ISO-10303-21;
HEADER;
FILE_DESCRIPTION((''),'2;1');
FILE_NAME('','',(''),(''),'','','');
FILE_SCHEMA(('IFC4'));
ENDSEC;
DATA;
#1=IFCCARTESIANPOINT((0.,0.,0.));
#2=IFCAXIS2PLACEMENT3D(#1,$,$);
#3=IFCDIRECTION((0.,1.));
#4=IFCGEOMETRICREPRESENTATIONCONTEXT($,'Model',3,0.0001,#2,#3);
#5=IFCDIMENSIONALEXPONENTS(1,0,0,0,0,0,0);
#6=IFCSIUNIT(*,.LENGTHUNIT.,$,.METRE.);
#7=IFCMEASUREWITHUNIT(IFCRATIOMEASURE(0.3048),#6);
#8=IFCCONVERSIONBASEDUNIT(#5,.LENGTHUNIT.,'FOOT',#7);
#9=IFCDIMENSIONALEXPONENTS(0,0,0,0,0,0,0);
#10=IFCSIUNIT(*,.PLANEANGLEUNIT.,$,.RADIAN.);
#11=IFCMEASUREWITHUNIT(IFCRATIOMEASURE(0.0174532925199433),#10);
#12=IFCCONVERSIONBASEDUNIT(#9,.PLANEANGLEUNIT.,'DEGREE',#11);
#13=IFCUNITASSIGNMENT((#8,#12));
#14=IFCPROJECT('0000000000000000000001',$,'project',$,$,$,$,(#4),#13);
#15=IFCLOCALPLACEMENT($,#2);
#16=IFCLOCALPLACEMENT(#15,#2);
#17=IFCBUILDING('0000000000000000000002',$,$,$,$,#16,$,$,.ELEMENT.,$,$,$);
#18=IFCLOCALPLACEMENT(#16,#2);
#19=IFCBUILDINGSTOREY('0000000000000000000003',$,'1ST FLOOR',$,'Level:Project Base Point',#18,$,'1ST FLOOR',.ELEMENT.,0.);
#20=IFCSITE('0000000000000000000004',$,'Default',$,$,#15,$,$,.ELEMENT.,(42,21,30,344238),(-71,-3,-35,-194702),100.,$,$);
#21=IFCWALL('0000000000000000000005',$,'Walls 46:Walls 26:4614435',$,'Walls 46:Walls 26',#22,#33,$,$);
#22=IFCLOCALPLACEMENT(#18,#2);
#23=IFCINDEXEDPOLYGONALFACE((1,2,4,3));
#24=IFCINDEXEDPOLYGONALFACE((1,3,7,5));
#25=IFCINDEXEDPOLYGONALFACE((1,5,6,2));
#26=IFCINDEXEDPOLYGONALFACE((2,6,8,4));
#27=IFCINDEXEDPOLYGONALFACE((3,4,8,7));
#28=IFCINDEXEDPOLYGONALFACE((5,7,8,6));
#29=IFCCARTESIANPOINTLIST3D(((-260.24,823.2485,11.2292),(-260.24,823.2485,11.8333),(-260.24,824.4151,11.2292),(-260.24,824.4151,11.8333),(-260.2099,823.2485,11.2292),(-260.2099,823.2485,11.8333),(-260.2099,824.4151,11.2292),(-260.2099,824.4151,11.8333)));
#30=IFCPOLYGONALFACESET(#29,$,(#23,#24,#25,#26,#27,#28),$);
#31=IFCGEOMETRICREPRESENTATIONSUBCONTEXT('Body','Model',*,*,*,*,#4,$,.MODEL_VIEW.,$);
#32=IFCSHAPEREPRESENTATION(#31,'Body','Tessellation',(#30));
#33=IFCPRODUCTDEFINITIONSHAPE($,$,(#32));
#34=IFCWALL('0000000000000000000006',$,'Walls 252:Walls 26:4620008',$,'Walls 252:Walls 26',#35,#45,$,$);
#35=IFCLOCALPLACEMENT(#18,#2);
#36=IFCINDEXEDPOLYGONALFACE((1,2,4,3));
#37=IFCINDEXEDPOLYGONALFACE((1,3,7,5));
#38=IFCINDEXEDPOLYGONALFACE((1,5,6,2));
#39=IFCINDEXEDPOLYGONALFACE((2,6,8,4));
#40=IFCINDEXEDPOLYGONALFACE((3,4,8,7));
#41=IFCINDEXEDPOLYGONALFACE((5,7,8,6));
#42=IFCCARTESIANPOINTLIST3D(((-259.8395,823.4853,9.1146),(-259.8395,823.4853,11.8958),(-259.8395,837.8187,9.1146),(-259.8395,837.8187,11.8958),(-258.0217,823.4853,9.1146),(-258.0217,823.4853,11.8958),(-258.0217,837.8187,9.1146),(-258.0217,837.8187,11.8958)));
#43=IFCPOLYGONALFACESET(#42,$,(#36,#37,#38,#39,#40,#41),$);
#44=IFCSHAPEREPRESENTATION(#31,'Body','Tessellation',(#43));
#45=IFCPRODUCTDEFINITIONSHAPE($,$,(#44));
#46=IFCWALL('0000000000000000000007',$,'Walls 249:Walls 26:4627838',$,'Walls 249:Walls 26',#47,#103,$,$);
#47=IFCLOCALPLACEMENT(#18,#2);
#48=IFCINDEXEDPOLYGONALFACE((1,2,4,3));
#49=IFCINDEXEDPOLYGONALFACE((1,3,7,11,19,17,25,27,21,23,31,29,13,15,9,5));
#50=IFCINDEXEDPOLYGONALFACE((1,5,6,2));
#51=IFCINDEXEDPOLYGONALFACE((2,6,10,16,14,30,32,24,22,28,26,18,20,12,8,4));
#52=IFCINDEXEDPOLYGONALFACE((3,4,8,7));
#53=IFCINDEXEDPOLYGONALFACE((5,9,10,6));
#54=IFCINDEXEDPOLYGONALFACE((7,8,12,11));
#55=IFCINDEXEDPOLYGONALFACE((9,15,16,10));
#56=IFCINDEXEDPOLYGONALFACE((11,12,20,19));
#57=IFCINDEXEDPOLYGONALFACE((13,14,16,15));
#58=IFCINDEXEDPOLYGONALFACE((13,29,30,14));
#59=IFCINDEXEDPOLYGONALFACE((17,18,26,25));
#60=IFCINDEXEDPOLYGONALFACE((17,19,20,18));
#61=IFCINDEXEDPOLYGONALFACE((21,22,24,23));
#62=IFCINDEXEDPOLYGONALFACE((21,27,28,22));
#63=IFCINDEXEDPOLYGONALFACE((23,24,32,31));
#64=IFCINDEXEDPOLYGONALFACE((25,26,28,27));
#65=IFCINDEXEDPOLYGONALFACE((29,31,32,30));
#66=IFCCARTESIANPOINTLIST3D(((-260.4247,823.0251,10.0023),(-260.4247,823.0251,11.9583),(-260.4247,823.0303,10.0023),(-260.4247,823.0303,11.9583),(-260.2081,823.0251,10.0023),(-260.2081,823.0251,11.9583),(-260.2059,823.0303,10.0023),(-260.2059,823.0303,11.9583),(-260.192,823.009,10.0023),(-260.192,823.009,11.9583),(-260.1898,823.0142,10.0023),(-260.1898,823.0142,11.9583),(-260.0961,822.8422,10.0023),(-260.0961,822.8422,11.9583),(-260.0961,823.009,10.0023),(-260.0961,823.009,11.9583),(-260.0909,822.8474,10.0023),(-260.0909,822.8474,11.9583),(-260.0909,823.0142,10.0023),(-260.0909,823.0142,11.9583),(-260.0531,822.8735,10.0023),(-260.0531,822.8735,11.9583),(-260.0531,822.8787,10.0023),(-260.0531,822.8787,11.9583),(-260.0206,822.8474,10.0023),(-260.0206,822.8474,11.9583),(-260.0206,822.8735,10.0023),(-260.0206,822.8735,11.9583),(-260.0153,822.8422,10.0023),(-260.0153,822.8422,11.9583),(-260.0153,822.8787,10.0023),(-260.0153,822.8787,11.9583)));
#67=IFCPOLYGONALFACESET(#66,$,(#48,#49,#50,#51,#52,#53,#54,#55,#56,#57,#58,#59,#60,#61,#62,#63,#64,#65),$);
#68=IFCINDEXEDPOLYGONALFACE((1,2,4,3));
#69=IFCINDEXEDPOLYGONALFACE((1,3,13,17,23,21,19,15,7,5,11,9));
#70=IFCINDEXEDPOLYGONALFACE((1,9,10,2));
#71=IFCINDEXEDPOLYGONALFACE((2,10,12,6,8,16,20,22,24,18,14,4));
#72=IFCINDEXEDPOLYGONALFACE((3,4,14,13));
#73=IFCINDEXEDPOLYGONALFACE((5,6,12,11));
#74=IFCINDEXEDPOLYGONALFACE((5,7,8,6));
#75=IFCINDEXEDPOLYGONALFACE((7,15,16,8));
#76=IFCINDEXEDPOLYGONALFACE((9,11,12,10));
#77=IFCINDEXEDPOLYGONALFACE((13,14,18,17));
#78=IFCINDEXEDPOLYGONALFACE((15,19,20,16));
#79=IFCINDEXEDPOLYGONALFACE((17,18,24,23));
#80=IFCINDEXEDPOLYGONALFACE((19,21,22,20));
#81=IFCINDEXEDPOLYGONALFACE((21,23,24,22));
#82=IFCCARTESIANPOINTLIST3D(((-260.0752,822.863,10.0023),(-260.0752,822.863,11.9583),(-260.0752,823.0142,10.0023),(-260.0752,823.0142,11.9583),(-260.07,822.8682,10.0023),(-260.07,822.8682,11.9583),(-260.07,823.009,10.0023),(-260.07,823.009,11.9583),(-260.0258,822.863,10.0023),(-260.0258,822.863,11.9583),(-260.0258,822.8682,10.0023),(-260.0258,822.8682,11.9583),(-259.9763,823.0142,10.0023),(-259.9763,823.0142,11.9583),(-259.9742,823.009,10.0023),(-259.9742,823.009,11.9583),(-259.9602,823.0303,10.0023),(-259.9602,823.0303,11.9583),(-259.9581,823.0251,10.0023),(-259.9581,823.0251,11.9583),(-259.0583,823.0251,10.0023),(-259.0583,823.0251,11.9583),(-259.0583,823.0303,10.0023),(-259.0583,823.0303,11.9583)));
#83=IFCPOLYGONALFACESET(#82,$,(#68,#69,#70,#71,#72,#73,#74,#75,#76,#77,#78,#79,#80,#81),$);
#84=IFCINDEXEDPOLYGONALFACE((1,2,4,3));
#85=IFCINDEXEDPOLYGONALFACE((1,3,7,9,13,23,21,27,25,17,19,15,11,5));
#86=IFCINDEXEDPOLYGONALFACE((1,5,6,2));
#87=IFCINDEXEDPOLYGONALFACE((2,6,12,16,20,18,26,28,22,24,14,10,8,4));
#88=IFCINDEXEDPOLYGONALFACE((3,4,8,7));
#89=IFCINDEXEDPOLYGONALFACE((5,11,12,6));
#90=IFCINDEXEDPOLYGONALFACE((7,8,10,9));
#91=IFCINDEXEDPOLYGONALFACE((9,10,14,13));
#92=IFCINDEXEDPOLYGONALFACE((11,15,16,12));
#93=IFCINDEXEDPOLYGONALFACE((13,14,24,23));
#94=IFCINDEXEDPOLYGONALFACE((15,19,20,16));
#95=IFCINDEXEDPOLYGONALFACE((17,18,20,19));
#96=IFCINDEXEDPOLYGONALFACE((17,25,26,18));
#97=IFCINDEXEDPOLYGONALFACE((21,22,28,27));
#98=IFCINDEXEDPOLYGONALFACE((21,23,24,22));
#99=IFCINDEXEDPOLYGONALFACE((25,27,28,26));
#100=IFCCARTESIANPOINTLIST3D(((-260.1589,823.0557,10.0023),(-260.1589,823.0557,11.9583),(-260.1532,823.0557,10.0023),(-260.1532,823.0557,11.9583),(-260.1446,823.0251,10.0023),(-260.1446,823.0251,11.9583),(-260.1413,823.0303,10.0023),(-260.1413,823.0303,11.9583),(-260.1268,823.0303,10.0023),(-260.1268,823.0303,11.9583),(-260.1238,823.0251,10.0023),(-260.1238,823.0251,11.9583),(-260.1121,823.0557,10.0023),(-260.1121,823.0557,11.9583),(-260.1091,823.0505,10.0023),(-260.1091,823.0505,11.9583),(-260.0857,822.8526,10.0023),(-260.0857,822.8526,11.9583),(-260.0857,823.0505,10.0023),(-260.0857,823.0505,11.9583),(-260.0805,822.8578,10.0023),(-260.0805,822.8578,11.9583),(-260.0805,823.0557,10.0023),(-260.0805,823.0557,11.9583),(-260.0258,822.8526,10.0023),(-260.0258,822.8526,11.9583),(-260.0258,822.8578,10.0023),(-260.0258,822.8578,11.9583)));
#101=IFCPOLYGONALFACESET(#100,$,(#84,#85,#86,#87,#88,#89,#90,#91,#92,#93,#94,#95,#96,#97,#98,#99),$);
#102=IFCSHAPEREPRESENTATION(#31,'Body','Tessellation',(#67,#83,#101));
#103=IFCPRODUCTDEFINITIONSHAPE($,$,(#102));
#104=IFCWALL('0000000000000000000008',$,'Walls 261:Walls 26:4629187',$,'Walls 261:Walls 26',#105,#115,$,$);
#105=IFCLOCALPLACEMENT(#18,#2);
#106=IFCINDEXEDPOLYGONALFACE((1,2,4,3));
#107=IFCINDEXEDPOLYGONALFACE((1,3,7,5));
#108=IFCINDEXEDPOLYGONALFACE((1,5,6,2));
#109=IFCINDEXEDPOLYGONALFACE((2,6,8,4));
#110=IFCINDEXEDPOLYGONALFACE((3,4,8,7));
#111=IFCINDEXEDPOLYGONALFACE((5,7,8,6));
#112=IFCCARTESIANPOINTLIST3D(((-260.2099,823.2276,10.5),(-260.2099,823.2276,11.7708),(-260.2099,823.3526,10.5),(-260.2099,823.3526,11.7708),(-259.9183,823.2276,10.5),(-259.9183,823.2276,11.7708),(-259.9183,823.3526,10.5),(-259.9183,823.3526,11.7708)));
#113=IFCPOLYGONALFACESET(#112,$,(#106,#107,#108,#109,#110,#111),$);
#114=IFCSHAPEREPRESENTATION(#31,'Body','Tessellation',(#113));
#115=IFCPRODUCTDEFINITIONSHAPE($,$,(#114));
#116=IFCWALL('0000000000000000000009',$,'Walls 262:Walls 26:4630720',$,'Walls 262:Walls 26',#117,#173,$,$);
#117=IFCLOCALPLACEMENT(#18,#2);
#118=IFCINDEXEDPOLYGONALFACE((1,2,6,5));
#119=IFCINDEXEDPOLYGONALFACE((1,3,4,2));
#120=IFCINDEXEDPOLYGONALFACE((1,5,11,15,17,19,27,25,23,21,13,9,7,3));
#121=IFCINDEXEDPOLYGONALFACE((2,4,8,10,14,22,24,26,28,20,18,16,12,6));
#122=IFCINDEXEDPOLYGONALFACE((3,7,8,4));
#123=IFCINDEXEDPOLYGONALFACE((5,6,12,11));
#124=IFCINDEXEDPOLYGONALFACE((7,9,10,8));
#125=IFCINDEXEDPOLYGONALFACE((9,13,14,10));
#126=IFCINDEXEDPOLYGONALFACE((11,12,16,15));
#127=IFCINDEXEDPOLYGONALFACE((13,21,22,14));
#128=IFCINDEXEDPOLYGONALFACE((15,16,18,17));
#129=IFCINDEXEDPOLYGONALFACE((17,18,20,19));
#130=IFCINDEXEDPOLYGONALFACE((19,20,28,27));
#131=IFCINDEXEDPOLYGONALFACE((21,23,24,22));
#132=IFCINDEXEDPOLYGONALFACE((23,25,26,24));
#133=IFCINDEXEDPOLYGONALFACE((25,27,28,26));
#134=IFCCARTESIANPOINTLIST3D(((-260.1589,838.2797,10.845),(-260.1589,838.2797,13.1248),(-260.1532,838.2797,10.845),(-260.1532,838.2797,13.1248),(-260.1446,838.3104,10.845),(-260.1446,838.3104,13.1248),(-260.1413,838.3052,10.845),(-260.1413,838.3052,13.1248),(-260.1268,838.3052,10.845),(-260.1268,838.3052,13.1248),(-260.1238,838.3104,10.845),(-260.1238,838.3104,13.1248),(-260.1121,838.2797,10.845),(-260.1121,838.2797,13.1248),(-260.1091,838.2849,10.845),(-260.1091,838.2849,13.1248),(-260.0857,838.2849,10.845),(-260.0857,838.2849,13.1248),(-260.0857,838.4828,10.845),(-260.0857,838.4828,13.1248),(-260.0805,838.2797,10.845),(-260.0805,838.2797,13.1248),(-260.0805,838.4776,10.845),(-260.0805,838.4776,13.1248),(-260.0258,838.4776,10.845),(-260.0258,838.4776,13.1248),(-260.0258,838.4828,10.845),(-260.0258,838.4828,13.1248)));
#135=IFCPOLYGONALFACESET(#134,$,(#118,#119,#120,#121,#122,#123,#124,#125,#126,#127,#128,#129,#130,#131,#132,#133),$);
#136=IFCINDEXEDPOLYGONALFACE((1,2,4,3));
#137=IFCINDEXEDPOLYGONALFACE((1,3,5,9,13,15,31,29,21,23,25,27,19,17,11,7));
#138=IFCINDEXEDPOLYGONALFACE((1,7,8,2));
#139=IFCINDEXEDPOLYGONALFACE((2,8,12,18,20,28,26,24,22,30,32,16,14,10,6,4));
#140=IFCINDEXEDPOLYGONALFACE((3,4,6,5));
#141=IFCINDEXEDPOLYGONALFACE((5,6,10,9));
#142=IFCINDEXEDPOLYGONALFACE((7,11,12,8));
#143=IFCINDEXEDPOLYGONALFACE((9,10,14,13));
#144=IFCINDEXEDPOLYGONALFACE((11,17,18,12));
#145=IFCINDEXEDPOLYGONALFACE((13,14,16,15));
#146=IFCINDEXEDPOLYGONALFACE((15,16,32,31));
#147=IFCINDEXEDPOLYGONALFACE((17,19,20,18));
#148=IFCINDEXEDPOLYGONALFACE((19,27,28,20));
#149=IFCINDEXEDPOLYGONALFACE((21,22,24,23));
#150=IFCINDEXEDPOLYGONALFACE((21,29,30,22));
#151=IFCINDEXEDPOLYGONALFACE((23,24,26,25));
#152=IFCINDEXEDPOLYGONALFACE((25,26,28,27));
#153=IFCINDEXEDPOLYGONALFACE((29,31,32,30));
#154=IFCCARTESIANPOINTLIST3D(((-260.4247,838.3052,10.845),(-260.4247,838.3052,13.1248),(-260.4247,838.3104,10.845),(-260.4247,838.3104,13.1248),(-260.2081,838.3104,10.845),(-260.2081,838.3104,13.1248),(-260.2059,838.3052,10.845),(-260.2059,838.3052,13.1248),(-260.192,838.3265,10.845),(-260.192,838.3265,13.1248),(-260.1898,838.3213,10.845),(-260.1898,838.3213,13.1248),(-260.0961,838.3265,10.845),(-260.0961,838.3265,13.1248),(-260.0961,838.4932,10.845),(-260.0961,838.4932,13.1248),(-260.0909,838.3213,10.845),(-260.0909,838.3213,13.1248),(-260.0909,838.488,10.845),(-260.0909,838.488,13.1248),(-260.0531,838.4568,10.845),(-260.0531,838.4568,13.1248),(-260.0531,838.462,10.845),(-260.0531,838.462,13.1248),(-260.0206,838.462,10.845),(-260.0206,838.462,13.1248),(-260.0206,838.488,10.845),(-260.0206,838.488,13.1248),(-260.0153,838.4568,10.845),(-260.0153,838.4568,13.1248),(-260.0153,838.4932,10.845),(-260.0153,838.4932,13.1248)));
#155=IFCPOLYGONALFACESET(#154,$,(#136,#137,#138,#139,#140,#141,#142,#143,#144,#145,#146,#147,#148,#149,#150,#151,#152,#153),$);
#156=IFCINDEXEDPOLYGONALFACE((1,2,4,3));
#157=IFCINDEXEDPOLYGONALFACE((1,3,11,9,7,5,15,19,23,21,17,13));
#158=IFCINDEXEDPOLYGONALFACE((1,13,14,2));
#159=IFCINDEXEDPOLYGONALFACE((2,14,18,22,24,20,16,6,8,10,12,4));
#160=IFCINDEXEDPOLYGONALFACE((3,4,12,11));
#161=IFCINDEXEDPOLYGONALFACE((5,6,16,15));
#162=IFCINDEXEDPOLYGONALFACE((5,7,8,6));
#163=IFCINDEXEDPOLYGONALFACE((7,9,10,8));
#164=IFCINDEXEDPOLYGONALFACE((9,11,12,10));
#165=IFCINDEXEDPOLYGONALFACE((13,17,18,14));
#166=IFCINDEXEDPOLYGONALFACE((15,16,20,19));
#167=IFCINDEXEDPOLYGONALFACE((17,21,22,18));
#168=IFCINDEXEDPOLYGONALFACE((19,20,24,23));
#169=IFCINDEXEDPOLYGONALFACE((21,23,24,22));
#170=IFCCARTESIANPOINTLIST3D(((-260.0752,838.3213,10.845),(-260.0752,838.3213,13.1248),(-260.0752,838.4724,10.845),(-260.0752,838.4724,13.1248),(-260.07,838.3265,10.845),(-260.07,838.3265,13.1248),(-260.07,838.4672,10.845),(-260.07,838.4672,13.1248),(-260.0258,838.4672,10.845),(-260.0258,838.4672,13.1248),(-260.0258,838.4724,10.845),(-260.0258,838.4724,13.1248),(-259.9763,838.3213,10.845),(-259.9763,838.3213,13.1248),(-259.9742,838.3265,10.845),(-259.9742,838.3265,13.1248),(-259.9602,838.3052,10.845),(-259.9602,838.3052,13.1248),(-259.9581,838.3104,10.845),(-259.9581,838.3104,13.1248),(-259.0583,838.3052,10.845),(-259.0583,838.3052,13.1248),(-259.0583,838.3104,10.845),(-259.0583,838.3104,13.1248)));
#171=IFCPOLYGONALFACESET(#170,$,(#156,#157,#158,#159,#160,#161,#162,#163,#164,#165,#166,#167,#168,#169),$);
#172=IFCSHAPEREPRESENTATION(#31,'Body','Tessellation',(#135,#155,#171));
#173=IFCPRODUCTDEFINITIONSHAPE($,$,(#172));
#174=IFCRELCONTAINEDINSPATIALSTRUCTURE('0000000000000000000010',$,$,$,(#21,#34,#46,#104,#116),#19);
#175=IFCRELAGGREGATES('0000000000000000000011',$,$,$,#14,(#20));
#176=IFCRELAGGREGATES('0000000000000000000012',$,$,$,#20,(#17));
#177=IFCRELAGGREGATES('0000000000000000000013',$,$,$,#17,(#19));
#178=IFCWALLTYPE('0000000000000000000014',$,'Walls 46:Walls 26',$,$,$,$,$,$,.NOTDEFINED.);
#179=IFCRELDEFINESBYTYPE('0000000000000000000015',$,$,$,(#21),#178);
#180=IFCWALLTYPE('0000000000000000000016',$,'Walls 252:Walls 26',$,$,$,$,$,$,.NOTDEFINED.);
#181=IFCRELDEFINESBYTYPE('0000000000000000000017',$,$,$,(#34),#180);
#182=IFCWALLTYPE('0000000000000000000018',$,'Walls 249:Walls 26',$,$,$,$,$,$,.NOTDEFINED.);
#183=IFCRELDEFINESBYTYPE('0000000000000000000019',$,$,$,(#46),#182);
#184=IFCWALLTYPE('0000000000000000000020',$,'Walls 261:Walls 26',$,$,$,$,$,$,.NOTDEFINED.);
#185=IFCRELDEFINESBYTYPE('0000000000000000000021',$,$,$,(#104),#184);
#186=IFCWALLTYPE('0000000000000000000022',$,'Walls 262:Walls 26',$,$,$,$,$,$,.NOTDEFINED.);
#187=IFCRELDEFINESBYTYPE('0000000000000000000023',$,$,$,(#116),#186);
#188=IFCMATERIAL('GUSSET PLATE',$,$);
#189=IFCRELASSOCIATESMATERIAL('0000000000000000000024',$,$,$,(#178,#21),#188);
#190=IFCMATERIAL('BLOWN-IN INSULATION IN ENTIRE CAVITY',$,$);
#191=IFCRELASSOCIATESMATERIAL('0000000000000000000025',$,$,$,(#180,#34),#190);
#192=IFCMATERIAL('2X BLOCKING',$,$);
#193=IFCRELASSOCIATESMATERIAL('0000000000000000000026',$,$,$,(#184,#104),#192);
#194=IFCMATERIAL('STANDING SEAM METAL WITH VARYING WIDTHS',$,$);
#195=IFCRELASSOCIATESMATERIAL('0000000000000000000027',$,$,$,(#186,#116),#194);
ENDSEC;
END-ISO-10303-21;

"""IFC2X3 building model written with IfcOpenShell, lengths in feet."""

from ifc_helpers import new_model, entity, si_unit, converted_unit, direction, frame, frame_2d, origin, origin_2d_with_axis, place, context, subcontext, project, spatial, polyline, rectangle, outline, extrude, material, type_object, element, save


model = new_model("IFC2X3")

# Units and contexts
model_context = context("Model", 3, precision=0.0001, world=origin(), true_north=direction((0.0, 1.0)))
body_context = subcontext(model_context, "Body", "Model", "MODEL_VIEW")
ifc_project = project(units=[converted_unit("LENGTHUNIT", "FOOT", entity("IfcRatioMeasure", 0.3048), si_unit("LENGTHUNIT", "METRE"), dimensions=[1, 0, 0, 0, 0, 0, 0]), converted_unit("PLANEANGLEUNIT", "DEGREE", entity("IfcRatioMeasure", 0.0174532925199433), si_unit("PLANEANGLEUNIT", "RADIAN"), dimensions=[0, 0, 0, 0, 0, 0, 0])], contexts=[model_context])

# Site, building, storey
site_placement = place(None, origin())
site = spatial("IfcSite", under=ifc_project, at=site_placement, Name="Default", CompositionType="ELEMENT", RefLatitude=(42, 21, 30, 344238), RefLongitude=(-71, -3, -35, -194702), RefElevation=100.0)
building_placement = place(site_placement, origin())
building = spatial("IfcBuilding", under=site, at=building_placement, CompositionType="ELEMENT")
storey_placement = place(building_placement, origin())
storey = spatial("IfcBuildingStorey", under=building, at=storey_placement, Name="1ST FLOOR", ObjectType="Level:Project Base Point", LongName="1ST FLOOR", CompositionType="ELEMENT", Elevation=0.0)

# Walls
ifc_material_1 = material(Name="GUSSET PLATE")
wall_type_1 = type_object("IfcWallType", Name="Walls 46:Walls 26", PredefinedType="NOTDEFINED", material=ifc_material_1)
wall_1_placement = place(storey_placement, frame((-260.24, 823.2485, 11.2292), z_axis=(0.0, 0.0, 1.0), x_axis=(0.0, 1.0, 0.0)))
element("IfcWall", 1, at=wall_1_placement, inside=storey, type_object=wall_type_1, material=ifc_material_1, Name="Walls 46:Walls 26:4614435", ObjectType="Walls 46:Walls 26", context=body_context, shape_type="SweptSolid", body=[
    extrude(rectangle(XDim=0.0301, YDim=1.1667, at=frame_2d((0.0, 0.0), x_axis=(1.0, 0.0))), frame((0.5833, -0.0151, 0.0), z_axis=(0.0, 0.0, 1.0), x_axis=(0.0, 1.0, 0.0)), (0.0, 0.0, 1.0), 0.6042),
])
ifc_material_2 = material(Name="BLOWN-IN INSULATION IN ENTIRE CAVITY")
wall_type_2 = type_object("IfcWallType", Name="Walls 252:Walls 26", PredefinedType="NOTDEFINED", material=ifc_material_2)
wall_2_placement = place(storey_placement, frame((-259.8395, 823.4853, 9.1146), z_axis=(0.0, 0.0, 1.0), x_axis=(0.0, 1.0, 0.0)))
element("IfcWall", 2, at=wall_2_placement, inside=storey, type_object=wall_type_2, material=ifc_material_2, Name="Walls 252:Walls 26:4620008", ObjectType="Walls 252:Walls 26", context=body_context, shape_type="SweptSolid", body=[
    extrude(rectangle(XDim=1.8178, YDim=14.3333, at=origin_2d_with_axis()), frame((7.1667, -0.9089, 0.0), z_axis=(0.0, 0.0, 1.0), x_axis=(0.0, 1.0, 0.0)), (0.0, 0.0, 1.0), 2.7812),
])
wall_type_3 = type_object("IfcWallType", Name="Walls 249:Walls 26", PredefinedType="NOTDEFINED")
wall_3_placement = place(storey_placement, frame((-260.4247, 822.8422, 9.9948)))
element("IfcWall", 3, at=wall_3_placement, inside=storey, type_object=wall_type_3, Name="Walls 249:Walls 26:4627838", ObjectType="Walls 249:Walls 26", context=body_context, shape_type="SweptSolid", body=[
    extrude(outline(polyline([(-0.2873, -0.085), (-0.2873, -0.0903), (-0.0686, -0.0903), (-0.0525, -0.0742), (0.0464, -0.0742), (0.0464, 0.0926), (0.1168, 0.0926), (0.1168, 0.0666), (0.0842, 0.0666), (0.0842, 0.0614), (0.122, 0.0614), (0.122, 0.0978), (0.0412, 0.0978), (0.0412, -0.0689), (-0.0546, -0.0689), (-0.0707, -0.085), (-0.2873, -0.085)])), frame((0.2873, 0.0978, 0.0075), z_axis=(0.0, 0.0, -1.0), x_axis=(1.0, 0.0, 0.0)), (0.0, 0.0, -1.0), 1.956),
    extrude(outline(polyline([(-0.2146, -0.1053), (-0.1651, -0.1053), (-0.1651, -0.1001), (-0.2094, -0.1001), (-0.2094, 0.0407), (-0.1135, 0.0407), (-0.0974, 0.0568), (0.8023, 0.0568), (0.8023, 0.062), (-0.0996, 0.062), (-0.1157, 0.0459), (-0.2146, 0.0459), (-0.2146, -0.1053)])), frame((0.564, 0.1261, 0.0075)), (0.0, 0.0, 1.0), 1.956),
    extrude(outline(polyline([(0.0182, -0.1371), (0.0781, -0.1371), (0.0781, -0.1319), (0.0234, -0.1319), (0.0234, 0.0661), (-0.0083, 0.0661), (-0.023, 0.0406), (-0.0375, 0.0406), (-0.0494, 0.0661), (-0.0551, 0.0661), (-0.0408, 0.0354), (-0.02, 0.0354), (-0.0053, 0.0608), (0.0182, 0.0608), (0.0182, -0.1371)])), frame((0.3208, 0.1475, 0.0075)), (0.0, 0.0, 1.0), 1.956),
])
ifc_material_3 = material(Name="2X BLOCKING")
wall_type_4 = type_object("IfcWallType", Name="Walls 261:Walls 26", PredefinedType="NOTDEFINED", material=ifc_material_3)
wall_4_placement = place(storey_placement, frame((-260.2099, 823.2276, 10.5)))
element("IfcWall", 4, at=wall_4_placement, inside=storey, type_object=wall_type_4, material=ifc_material_3, Name="Walls 261:Walls 26:4629187", ObjectType="Walls 261:Walls 26", context=body_context, shape_type="SweptSolid", body=[
    extrude(rectangle(XDim=0.2917, YDim=0.125, at=frame_2d((0.0, 0.0), x_axis=(1.0, 0.0))), frame((0.1458, 0.0625, 0.0), z_axis=(0.0, 0.0, 1.0), x_axis=(-1.0, 0.0, 0.0)), (0.0, 0.0, 1.0), 1.2708),
])
ifc_material_4 = material(Name="STANDING SEAM METAL WITH VARYING WIDTHS")
wall_type_5 = type_object("IfcWallType", Name="Walls 262:Walls 26", PredefinedType="NOTDEFINED", material=ifc_material_4)
wall_5_placement = place(storey_placement, frame((-260.4247, 838.2797, 10.845)))
element("IfcWall", 5, at=wall_5_placement, inside=storey, type_object=wall_type_5, material=ifc_material_4, Name="Walls 262:Walls 26:4630720", ObjectType="Walls 262:Walls 26", context=body_context, shape_type="SweptSolid", body=[
    extrude(outline(polyline([(-0.1371, -0.0182), (-0.1371, -0.0781), (-0.1319, -0.0781), (-0.1319, -0.0234), (0.0661, -0.0234), (0.0661, 0.0083), (0.0406, 0.023), (0.0406, 0.0375), (0.0661, 0.0494), (0.0661, 0.0551), (0.0354, 0.0408), (0.0354, 0.02), (0.0608, 0.0053), (0.0608, -0.0182), (-0.1371, -0.0182)])), frame((0.3208, 0.0661, 0.0), z_axis=(0.0, 0.0, -1.0), x_axis=(0.0, -1.0, 0.0)), (0.0, 0.0, -1.0), 2.2798),
    extrude(outline(polyline([(0.085, -0.2873), (0.0903, -0.2873), (0.0903, -0.0686), (0.0742, -0.0525), (0.0742, 0.0464), (-0.0926, 0.0464), (-0.0926, 0.1168), (-0.0666, 0.1168), (-0.0666, 0.0842), (-0.0614, 0.0842), (-0.0614, 0.122), (-0.0978, 0.122), (-0.0978, 0.0412), (0.0689, 0.0412), (0.0689, -0.0546), (0.085, -0.0707), (0.085, -0.2873)])), frame((0.2873, 0.1157, 0.0), z_axis=(0.0, 0.0, 1.0), x_axis=(0.0, -1.0, 0.0)), (0.0, 0.0, 1.0), 2.2798),
    extrude(outline(polyline([(-0.1053, -0.2146), (0.0459, -0.2146), (0.0459, -0.1157), (0.062, -0.0996), (0.062, 0.8023), (0.0568, 0.8023), (0.0568, -0.0974), (0.0407, -0.1135), (0.0407, -0.2094), (-0.1001, -0.2094), (-0.1001, -0.1651), (-0.1053, -0.1651), (-0.1053, -0.2146)])), frame((0.564, 0.0874, 0.0), z_axis=(0.0, 0.0, 1.0), x_axis=(0.0, -1.0, 0.0)), (0.0, 0.0, 1.0), 2.2798),
])

save(model, "model.ifc")
